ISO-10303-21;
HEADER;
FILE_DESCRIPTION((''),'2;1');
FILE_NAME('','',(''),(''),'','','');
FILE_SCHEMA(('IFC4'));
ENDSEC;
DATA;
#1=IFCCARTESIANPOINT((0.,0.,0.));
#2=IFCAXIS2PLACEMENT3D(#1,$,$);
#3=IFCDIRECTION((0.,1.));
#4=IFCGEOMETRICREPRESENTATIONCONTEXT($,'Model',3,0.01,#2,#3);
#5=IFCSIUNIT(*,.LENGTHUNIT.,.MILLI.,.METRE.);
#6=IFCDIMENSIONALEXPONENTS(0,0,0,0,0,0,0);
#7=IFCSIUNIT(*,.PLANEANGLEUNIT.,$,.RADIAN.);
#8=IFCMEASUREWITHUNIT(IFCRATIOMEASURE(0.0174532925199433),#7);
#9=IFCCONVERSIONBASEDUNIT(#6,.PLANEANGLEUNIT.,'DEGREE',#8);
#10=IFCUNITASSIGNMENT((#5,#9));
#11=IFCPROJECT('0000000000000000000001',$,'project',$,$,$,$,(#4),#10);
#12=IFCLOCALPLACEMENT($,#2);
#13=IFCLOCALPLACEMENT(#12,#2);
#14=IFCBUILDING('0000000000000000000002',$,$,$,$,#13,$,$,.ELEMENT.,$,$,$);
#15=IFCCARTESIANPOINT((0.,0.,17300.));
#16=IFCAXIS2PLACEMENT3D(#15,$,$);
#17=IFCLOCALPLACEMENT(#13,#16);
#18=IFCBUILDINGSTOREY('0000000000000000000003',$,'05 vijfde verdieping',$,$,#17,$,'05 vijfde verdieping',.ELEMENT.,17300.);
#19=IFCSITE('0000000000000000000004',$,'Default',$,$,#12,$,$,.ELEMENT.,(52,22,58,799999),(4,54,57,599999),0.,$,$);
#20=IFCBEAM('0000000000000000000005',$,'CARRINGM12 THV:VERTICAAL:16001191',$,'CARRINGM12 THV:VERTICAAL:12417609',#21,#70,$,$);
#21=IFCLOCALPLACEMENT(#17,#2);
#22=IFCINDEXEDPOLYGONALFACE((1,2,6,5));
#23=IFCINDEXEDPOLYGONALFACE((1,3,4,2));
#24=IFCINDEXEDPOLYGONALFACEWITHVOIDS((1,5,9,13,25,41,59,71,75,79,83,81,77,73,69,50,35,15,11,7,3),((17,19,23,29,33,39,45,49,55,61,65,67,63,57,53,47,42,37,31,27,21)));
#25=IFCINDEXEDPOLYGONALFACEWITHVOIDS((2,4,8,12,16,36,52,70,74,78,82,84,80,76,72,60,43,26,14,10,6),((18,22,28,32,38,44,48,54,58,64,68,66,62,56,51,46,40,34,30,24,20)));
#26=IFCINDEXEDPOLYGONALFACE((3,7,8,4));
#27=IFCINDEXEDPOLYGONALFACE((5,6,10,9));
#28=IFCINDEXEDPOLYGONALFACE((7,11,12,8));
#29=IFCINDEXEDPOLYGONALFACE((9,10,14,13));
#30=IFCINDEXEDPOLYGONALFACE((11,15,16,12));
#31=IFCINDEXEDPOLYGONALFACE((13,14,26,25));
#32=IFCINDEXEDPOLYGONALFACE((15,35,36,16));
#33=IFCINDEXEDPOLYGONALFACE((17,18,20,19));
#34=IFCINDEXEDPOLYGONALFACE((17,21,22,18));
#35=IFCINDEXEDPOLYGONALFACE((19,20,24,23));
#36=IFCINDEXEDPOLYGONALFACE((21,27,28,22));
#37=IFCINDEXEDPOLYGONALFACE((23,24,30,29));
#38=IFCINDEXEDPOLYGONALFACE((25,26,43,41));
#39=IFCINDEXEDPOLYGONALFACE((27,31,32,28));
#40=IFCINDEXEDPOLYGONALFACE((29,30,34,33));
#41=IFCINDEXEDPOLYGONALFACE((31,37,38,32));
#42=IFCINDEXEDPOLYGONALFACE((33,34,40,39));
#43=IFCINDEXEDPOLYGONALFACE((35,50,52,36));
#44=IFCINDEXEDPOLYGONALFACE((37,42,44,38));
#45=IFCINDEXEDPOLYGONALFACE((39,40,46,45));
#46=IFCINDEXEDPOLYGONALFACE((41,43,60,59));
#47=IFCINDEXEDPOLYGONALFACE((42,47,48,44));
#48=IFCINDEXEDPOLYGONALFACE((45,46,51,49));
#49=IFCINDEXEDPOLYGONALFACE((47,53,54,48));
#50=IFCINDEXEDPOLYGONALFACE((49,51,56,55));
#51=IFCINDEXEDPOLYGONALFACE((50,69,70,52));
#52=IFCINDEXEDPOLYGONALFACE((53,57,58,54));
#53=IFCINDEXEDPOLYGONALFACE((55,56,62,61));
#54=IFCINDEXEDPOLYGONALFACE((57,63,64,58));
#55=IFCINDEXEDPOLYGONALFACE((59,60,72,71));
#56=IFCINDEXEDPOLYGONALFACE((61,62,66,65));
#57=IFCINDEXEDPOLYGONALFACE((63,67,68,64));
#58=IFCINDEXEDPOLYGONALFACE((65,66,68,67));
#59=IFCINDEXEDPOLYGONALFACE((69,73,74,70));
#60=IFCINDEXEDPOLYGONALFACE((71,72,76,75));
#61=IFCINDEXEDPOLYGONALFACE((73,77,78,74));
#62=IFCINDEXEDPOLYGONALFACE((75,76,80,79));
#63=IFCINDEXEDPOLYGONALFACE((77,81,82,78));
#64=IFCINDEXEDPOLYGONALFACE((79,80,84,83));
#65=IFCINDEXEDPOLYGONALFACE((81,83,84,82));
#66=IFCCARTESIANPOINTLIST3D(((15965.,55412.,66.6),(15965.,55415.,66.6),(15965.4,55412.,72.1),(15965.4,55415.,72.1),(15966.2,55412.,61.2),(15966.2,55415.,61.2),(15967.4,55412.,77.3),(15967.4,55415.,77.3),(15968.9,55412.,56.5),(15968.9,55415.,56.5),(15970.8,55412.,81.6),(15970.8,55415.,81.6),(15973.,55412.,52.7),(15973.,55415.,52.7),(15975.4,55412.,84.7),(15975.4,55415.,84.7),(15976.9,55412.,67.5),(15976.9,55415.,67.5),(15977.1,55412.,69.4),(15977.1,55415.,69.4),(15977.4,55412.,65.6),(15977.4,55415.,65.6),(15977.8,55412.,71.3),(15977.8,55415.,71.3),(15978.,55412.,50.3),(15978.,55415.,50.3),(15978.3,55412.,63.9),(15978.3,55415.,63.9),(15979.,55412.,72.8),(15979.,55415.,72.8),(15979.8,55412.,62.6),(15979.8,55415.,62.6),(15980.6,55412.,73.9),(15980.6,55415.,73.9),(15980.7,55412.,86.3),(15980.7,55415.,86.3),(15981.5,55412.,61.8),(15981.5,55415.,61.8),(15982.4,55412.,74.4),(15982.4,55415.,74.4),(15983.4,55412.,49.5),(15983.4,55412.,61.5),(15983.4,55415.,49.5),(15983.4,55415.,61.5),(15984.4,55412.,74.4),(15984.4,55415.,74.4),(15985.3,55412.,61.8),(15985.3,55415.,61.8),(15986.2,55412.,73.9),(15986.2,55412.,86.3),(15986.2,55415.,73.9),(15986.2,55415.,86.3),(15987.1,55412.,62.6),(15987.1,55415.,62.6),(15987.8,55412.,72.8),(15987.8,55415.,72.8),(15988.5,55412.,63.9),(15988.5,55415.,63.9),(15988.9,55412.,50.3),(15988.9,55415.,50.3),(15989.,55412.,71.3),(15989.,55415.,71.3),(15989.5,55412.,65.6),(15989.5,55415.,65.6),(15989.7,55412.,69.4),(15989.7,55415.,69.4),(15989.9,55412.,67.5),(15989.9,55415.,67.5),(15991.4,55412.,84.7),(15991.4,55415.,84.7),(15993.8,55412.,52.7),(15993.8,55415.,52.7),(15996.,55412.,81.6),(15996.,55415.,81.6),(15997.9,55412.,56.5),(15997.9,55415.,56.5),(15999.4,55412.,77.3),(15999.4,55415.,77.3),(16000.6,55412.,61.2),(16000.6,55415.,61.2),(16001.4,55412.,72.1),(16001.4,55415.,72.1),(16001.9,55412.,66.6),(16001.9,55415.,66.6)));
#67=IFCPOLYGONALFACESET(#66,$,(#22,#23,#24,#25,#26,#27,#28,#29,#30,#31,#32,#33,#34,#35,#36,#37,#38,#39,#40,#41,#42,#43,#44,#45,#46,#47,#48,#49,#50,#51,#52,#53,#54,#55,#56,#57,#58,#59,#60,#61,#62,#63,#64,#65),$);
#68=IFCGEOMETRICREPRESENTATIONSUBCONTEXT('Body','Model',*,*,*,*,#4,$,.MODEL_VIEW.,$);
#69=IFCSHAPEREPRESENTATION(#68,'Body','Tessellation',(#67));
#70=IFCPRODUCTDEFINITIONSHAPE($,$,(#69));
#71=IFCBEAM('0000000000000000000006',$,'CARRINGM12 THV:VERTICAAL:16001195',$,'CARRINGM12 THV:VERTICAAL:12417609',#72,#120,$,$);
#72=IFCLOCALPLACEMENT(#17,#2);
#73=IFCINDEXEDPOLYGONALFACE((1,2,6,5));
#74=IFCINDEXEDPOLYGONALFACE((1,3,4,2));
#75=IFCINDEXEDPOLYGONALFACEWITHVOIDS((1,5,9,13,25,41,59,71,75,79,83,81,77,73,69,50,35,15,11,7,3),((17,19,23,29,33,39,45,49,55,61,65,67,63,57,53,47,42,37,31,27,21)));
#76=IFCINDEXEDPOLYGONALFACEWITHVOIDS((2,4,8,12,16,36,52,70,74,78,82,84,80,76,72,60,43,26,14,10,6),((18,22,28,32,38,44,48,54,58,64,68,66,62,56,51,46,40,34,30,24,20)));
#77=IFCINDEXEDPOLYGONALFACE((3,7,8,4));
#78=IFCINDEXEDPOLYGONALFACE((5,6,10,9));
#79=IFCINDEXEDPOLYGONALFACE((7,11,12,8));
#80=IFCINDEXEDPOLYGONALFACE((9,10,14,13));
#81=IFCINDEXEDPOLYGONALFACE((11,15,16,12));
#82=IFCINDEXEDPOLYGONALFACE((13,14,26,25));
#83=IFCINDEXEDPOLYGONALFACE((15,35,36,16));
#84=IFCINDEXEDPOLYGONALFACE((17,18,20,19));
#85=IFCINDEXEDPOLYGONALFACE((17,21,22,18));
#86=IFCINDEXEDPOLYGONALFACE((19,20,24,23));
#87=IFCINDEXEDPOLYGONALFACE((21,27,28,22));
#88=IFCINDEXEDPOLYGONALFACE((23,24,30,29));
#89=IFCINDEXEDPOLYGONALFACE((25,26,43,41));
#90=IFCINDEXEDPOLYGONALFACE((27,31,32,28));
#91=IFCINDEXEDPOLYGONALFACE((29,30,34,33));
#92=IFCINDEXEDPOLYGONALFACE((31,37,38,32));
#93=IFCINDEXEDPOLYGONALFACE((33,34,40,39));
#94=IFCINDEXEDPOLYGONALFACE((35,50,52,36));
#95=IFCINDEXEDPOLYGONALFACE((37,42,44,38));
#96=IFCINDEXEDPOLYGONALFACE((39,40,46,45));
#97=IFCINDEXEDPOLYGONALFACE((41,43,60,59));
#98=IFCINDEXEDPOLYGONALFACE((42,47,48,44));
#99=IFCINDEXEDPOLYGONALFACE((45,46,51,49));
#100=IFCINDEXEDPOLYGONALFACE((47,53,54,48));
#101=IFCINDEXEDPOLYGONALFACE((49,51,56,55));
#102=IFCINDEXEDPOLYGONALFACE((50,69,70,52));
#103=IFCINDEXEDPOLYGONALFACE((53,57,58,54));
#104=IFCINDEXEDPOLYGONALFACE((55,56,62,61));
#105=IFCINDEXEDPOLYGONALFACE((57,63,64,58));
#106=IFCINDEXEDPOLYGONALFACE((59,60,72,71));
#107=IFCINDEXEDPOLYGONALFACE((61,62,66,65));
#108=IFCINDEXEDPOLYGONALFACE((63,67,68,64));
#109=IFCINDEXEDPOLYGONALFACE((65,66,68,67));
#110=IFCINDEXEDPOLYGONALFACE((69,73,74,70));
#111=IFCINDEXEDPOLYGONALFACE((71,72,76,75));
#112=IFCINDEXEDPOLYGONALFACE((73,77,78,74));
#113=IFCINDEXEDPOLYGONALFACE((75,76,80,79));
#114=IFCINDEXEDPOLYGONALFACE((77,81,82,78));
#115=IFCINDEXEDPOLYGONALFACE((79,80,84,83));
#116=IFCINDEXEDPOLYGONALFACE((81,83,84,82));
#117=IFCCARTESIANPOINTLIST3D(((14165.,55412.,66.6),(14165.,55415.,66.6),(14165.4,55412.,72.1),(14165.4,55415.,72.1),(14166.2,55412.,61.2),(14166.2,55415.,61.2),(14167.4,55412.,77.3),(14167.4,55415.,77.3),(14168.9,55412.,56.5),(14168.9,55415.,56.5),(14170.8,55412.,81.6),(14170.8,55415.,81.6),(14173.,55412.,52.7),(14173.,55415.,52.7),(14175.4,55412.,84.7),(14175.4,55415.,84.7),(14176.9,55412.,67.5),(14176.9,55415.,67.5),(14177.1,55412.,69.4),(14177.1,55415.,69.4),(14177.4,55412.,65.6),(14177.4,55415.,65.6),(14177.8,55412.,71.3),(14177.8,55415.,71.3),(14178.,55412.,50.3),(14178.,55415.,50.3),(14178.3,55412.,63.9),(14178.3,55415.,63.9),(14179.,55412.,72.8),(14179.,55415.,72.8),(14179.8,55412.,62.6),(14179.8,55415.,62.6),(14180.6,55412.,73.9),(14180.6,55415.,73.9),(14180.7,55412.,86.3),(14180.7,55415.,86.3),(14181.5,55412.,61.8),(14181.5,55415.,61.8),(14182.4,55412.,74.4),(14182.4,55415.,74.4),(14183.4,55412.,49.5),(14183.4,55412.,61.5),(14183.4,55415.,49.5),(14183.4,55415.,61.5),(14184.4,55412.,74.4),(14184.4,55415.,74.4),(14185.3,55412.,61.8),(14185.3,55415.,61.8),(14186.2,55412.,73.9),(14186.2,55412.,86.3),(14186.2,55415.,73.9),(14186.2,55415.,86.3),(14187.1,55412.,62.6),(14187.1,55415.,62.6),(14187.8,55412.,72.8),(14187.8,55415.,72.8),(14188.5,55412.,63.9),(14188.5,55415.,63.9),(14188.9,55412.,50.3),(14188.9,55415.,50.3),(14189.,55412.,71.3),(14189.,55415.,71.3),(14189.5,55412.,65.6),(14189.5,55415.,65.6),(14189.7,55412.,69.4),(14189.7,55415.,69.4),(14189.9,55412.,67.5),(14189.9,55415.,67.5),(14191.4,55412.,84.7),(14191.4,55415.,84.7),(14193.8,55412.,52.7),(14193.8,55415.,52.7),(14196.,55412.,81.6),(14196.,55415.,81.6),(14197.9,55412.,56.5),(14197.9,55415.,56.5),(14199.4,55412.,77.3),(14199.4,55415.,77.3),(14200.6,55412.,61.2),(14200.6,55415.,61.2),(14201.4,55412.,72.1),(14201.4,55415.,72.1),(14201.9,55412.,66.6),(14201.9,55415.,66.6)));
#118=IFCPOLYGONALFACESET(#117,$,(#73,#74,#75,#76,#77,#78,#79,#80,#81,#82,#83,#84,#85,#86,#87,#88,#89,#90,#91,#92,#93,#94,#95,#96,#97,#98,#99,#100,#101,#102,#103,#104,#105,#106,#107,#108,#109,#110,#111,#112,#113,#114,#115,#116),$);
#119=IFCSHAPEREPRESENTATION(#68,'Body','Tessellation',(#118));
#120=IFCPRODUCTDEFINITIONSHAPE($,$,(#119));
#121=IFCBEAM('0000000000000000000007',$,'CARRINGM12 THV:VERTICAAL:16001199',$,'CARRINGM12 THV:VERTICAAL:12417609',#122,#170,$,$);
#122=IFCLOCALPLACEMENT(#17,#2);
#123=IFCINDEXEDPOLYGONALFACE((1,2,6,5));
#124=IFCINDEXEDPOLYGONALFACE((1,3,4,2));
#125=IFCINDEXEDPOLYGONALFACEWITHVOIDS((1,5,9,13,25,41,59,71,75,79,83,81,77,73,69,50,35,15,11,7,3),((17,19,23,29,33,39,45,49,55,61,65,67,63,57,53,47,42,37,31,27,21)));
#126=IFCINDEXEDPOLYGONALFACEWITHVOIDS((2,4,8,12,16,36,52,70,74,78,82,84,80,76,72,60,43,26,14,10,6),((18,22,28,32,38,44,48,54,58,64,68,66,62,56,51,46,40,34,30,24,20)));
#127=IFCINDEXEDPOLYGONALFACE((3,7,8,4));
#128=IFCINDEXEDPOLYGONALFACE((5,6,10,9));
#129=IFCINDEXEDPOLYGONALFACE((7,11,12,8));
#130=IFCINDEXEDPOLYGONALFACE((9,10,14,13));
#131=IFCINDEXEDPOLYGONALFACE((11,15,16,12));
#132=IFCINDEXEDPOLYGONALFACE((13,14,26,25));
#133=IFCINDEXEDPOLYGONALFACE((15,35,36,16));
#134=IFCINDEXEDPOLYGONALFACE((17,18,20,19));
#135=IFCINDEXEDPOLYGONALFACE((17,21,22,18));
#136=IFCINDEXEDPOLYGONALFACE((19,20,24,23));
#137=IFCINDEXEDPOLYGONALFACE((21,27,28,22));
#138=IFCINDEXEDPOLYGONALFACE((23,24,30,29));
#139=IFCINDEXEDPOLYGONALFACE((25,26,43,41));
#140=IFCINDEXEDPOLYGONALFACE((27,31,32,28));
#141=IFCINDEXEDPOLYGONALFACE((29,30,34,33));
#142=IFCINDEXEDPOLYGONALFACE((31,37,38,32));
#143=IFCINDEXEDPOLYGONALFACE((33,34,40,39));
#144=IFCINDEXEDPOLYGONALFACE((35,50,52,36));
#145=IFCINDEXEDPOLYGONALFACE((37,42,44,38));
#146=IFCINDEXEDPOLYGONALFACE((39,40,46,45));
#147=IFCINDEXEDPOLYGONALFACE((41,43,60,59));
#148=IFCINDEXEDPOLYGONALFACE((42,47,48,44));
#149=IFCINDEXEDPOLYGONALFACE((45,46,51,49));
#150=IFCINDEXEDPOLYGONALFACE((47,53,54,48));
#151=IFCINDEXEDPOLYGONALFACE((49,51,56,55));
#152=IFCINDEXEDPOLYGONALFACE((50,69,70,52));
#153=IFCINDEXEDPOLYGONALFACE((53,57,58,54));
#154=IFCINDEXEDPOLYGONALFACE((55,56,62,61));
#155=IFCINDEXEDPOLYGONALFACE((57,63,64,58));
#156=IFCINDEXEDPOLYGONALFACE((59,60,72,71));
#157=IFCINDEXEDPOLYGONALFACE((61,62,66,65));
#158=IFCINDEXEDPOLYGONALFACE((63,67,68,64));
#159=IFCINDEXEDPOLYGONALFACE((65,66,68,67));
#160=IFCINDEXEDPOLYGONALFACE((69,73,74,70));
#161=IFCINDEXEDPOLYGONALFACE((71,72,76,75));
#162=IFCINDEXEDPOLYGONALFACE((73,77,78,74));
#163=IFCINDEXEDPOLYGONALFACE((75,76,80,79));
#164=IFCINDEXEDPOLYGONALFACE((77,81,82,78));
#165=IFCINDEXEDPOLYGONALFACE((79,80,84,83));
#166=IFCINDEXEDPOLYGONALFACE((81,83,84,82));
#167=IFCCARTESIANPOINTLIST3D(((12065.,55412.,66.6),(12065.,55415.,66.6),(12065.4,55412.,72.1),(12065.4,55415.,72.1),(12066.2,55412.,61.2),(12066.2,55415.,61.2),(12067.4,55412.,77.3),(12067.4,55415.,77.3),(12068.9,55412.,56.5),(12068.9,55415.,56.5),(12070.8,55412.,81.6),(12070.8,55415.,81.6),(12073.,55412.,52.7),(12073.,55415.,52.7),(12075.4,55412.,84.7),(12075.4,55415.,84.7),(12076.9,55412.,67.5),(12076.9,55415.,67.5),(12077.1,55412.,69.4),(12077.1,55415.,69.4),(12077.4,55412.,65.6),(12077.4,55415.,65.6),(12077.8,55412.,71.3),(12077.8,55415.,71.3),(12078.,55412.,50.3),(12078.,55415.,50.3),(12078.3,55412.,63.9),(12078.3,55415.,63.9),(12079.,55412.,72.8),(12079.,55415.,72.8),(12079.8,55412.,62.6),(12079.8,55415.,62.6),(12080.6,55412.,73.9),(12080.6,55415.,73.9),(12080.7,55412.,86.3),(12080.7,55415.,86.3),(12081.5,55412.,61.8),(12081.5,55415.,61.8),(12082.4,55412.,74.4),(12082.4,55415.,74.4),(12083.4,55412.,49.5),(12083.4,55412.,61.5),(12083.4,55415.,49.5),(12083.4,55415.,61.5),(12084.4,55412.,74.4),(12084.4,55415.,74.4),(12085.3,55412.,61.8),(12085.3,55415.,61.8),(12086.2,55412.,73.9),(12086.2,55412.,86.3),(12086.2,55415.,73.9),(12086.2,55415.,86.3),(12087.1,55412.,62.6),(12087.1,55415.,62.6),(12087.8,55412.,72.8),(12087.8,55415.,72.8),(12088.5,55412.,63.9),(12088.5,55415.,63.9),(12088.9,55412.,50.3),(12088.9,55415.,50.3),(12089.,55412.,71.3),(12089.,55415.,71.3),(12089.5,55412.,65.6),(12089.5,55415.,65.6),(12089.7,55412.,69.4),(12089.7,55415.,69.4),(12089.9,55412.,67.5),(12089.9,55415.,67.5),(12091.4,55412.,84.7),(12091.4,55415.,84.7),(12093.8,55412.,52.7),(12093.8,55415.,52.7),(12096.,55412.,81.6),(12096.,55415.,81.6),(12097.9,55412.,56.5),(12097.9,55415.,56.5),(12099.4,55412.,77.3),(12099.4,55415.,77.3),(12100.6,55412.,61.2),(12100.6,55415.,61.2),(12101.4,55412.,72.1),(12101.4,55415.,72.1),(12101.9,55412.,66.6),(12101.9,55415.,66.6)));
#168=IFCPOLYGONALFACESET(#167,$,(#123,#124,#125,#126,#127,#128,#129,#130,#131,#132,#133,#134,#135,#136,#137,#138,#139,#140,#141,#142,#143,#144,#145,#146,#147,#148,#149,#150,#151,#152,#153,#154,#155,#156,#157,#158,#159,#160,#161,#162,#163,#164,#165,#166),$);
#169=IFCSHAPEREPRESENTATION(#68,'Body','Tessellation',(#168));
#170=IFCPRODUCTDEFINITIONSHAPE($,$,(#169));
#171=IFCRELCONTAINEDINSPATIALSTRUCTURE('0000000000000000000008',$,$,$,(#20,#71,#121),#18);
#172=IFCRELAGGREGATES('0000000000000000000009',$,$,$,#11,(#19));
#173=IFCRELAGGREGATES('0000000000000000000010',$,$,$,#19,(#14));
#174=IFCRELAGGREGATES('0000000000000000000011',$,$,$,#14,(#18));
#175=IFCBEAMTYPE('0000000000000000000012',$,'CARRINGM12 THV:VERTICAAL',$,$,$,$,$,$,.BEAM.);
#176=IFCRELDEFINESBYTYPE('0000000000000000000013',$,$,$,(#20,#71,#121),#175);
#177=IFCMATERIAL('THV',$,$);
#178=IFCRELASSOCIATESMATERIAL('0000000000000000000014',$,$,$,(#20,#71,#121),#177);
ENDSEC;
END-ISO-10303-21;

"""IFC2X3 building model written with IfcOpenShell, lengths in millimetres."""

from ifc_helpers import new_model, entity, si_unit, converted_unit, direction, frame, origin, origin_2d_with_axis, place, context, subcontext, project, spatial, hollow_circle, extrude, material, type_object, element, save


model = new_model("IFC2X3")

# Units and contexts
model_context = context("Model", 3, precision=0.01, world=origin(), true_north=direction((0.0, 1.0)))
body_context = subcontext(model_context, "Body", "Model", "MODEL_VIEW")
ifc_project = project(units=[si_unit("LENGTHUNIT", "METRE", prefix="MILLI"), converted_unit("PLANEANGLEUNIT", "DEGREE", entity("IfcRatioMeasure", 0.0174532925199433), si_unit("PLANEANGLEUNIT", "RADIAN"), dimensions=[0, 0, 0, 0, 0, 0, 0])], contexts=[model_context])

# Site, building, storey
site_placement = place(None, origin())
site = spatial("IfcSite", under=ifc_project, at=site_placement, Name="Default", CompositionType="ELEMENT", RefLatitude=(52, 22, 58, 799999), RefLongitude=(4, 54, 57, 599999), RefElevation=0.0)
building_placement = place(site_placement, origin())
building = spatial("IfcBuilding", under=site, at=building_placement, CompositionType="ELEMENT")
storey_placement = place(building_placement, frame((0.0, 0.0, 17300.0)))
storey = spatial("IfcBuildingStorey", under=building, at=storey_placement, Name="05 vijfde verdieping", LongName="05 vijfde verdieping", CompositionType="ELEMENT", Elevation=17300.0)

# Beams
ifc_material_1 = material(Name="THV")
beam_type_1 = type_object("IfcBeamType", Name="CARRINGM12 THV:VERTICAAL", PredefinedType="BEAM")
beam_1_placement = place(storey_placement, origin())
element("IfcBeam", 1, at=beam_1_placement, inside=storey, type_object=beam_type_1, material=ifc_material_1, Name="CARRINGM12 THV:VERTICAAL:16001191", ObjectType="CARRINGM12 THV:VERTICAAL:12417609", context=body_context, shape_type="SweptSolid", body=[
    extrude(hollow_circle(Radius=18.5, WallThickness=12.0, at=origin_2d_with_axis()), frame((15983.4, 55412.0, 68.0), z_axis=(0.0, 1.0, 0.0), x_axis=(0.0, 0.0, -1.0)), (0.0, 0.0, 1.0), 3.0),
])
beam_2_placement = place(storey_placement, origin())
element("IfcBeam", 2, at=beam_2_placement, inside=storey, type_object=beam_type_1, material=ifc_material_1, Name="CARRINGM12 THV:VERTICAAL:16001195", ObjectType="CARRINGM12 THV:VERTICAAL:12417609", context=body_context, shape_type="SweptSolid", body=[
    extrude(hollow_circle(Radius=18.5, WallThickness=12.0, at=origin_2d_with_axis()), frame((14183.4, 55412.0, 68.0), z_axis=(0.0, 1.0, 0.0), x_axis=(0.0, 0.0, -1.0)), (0.0, 0.0, 1.0), 3.0),
])
beam_3_placement = place(storey_placement, origin())
element("IfcBeam", 3, at=beam_3_placement, inside=storey, type_object=beam_type_1, material=ifc_material_1, Name="CARRINGM12 THV:VERTICAAL:16001199", ObjectType="CARRINGM12 THV:VERTICAAL:12417609", context=body_context, shape_type="SweptSolid", body=[
    extrude(hollow_circle(Radius=18.5, WallThickness=12.0, at=origin_2d_with_axis()), frame((12083.4, 55412.0, 68.0), z_axis=(0.0, 1.0, 0.0), x_axis=(0.0, 0.0, -1.0)), (0.0, 0.0, 1.0), 3.0),
])

save(model, "model.ifc")
